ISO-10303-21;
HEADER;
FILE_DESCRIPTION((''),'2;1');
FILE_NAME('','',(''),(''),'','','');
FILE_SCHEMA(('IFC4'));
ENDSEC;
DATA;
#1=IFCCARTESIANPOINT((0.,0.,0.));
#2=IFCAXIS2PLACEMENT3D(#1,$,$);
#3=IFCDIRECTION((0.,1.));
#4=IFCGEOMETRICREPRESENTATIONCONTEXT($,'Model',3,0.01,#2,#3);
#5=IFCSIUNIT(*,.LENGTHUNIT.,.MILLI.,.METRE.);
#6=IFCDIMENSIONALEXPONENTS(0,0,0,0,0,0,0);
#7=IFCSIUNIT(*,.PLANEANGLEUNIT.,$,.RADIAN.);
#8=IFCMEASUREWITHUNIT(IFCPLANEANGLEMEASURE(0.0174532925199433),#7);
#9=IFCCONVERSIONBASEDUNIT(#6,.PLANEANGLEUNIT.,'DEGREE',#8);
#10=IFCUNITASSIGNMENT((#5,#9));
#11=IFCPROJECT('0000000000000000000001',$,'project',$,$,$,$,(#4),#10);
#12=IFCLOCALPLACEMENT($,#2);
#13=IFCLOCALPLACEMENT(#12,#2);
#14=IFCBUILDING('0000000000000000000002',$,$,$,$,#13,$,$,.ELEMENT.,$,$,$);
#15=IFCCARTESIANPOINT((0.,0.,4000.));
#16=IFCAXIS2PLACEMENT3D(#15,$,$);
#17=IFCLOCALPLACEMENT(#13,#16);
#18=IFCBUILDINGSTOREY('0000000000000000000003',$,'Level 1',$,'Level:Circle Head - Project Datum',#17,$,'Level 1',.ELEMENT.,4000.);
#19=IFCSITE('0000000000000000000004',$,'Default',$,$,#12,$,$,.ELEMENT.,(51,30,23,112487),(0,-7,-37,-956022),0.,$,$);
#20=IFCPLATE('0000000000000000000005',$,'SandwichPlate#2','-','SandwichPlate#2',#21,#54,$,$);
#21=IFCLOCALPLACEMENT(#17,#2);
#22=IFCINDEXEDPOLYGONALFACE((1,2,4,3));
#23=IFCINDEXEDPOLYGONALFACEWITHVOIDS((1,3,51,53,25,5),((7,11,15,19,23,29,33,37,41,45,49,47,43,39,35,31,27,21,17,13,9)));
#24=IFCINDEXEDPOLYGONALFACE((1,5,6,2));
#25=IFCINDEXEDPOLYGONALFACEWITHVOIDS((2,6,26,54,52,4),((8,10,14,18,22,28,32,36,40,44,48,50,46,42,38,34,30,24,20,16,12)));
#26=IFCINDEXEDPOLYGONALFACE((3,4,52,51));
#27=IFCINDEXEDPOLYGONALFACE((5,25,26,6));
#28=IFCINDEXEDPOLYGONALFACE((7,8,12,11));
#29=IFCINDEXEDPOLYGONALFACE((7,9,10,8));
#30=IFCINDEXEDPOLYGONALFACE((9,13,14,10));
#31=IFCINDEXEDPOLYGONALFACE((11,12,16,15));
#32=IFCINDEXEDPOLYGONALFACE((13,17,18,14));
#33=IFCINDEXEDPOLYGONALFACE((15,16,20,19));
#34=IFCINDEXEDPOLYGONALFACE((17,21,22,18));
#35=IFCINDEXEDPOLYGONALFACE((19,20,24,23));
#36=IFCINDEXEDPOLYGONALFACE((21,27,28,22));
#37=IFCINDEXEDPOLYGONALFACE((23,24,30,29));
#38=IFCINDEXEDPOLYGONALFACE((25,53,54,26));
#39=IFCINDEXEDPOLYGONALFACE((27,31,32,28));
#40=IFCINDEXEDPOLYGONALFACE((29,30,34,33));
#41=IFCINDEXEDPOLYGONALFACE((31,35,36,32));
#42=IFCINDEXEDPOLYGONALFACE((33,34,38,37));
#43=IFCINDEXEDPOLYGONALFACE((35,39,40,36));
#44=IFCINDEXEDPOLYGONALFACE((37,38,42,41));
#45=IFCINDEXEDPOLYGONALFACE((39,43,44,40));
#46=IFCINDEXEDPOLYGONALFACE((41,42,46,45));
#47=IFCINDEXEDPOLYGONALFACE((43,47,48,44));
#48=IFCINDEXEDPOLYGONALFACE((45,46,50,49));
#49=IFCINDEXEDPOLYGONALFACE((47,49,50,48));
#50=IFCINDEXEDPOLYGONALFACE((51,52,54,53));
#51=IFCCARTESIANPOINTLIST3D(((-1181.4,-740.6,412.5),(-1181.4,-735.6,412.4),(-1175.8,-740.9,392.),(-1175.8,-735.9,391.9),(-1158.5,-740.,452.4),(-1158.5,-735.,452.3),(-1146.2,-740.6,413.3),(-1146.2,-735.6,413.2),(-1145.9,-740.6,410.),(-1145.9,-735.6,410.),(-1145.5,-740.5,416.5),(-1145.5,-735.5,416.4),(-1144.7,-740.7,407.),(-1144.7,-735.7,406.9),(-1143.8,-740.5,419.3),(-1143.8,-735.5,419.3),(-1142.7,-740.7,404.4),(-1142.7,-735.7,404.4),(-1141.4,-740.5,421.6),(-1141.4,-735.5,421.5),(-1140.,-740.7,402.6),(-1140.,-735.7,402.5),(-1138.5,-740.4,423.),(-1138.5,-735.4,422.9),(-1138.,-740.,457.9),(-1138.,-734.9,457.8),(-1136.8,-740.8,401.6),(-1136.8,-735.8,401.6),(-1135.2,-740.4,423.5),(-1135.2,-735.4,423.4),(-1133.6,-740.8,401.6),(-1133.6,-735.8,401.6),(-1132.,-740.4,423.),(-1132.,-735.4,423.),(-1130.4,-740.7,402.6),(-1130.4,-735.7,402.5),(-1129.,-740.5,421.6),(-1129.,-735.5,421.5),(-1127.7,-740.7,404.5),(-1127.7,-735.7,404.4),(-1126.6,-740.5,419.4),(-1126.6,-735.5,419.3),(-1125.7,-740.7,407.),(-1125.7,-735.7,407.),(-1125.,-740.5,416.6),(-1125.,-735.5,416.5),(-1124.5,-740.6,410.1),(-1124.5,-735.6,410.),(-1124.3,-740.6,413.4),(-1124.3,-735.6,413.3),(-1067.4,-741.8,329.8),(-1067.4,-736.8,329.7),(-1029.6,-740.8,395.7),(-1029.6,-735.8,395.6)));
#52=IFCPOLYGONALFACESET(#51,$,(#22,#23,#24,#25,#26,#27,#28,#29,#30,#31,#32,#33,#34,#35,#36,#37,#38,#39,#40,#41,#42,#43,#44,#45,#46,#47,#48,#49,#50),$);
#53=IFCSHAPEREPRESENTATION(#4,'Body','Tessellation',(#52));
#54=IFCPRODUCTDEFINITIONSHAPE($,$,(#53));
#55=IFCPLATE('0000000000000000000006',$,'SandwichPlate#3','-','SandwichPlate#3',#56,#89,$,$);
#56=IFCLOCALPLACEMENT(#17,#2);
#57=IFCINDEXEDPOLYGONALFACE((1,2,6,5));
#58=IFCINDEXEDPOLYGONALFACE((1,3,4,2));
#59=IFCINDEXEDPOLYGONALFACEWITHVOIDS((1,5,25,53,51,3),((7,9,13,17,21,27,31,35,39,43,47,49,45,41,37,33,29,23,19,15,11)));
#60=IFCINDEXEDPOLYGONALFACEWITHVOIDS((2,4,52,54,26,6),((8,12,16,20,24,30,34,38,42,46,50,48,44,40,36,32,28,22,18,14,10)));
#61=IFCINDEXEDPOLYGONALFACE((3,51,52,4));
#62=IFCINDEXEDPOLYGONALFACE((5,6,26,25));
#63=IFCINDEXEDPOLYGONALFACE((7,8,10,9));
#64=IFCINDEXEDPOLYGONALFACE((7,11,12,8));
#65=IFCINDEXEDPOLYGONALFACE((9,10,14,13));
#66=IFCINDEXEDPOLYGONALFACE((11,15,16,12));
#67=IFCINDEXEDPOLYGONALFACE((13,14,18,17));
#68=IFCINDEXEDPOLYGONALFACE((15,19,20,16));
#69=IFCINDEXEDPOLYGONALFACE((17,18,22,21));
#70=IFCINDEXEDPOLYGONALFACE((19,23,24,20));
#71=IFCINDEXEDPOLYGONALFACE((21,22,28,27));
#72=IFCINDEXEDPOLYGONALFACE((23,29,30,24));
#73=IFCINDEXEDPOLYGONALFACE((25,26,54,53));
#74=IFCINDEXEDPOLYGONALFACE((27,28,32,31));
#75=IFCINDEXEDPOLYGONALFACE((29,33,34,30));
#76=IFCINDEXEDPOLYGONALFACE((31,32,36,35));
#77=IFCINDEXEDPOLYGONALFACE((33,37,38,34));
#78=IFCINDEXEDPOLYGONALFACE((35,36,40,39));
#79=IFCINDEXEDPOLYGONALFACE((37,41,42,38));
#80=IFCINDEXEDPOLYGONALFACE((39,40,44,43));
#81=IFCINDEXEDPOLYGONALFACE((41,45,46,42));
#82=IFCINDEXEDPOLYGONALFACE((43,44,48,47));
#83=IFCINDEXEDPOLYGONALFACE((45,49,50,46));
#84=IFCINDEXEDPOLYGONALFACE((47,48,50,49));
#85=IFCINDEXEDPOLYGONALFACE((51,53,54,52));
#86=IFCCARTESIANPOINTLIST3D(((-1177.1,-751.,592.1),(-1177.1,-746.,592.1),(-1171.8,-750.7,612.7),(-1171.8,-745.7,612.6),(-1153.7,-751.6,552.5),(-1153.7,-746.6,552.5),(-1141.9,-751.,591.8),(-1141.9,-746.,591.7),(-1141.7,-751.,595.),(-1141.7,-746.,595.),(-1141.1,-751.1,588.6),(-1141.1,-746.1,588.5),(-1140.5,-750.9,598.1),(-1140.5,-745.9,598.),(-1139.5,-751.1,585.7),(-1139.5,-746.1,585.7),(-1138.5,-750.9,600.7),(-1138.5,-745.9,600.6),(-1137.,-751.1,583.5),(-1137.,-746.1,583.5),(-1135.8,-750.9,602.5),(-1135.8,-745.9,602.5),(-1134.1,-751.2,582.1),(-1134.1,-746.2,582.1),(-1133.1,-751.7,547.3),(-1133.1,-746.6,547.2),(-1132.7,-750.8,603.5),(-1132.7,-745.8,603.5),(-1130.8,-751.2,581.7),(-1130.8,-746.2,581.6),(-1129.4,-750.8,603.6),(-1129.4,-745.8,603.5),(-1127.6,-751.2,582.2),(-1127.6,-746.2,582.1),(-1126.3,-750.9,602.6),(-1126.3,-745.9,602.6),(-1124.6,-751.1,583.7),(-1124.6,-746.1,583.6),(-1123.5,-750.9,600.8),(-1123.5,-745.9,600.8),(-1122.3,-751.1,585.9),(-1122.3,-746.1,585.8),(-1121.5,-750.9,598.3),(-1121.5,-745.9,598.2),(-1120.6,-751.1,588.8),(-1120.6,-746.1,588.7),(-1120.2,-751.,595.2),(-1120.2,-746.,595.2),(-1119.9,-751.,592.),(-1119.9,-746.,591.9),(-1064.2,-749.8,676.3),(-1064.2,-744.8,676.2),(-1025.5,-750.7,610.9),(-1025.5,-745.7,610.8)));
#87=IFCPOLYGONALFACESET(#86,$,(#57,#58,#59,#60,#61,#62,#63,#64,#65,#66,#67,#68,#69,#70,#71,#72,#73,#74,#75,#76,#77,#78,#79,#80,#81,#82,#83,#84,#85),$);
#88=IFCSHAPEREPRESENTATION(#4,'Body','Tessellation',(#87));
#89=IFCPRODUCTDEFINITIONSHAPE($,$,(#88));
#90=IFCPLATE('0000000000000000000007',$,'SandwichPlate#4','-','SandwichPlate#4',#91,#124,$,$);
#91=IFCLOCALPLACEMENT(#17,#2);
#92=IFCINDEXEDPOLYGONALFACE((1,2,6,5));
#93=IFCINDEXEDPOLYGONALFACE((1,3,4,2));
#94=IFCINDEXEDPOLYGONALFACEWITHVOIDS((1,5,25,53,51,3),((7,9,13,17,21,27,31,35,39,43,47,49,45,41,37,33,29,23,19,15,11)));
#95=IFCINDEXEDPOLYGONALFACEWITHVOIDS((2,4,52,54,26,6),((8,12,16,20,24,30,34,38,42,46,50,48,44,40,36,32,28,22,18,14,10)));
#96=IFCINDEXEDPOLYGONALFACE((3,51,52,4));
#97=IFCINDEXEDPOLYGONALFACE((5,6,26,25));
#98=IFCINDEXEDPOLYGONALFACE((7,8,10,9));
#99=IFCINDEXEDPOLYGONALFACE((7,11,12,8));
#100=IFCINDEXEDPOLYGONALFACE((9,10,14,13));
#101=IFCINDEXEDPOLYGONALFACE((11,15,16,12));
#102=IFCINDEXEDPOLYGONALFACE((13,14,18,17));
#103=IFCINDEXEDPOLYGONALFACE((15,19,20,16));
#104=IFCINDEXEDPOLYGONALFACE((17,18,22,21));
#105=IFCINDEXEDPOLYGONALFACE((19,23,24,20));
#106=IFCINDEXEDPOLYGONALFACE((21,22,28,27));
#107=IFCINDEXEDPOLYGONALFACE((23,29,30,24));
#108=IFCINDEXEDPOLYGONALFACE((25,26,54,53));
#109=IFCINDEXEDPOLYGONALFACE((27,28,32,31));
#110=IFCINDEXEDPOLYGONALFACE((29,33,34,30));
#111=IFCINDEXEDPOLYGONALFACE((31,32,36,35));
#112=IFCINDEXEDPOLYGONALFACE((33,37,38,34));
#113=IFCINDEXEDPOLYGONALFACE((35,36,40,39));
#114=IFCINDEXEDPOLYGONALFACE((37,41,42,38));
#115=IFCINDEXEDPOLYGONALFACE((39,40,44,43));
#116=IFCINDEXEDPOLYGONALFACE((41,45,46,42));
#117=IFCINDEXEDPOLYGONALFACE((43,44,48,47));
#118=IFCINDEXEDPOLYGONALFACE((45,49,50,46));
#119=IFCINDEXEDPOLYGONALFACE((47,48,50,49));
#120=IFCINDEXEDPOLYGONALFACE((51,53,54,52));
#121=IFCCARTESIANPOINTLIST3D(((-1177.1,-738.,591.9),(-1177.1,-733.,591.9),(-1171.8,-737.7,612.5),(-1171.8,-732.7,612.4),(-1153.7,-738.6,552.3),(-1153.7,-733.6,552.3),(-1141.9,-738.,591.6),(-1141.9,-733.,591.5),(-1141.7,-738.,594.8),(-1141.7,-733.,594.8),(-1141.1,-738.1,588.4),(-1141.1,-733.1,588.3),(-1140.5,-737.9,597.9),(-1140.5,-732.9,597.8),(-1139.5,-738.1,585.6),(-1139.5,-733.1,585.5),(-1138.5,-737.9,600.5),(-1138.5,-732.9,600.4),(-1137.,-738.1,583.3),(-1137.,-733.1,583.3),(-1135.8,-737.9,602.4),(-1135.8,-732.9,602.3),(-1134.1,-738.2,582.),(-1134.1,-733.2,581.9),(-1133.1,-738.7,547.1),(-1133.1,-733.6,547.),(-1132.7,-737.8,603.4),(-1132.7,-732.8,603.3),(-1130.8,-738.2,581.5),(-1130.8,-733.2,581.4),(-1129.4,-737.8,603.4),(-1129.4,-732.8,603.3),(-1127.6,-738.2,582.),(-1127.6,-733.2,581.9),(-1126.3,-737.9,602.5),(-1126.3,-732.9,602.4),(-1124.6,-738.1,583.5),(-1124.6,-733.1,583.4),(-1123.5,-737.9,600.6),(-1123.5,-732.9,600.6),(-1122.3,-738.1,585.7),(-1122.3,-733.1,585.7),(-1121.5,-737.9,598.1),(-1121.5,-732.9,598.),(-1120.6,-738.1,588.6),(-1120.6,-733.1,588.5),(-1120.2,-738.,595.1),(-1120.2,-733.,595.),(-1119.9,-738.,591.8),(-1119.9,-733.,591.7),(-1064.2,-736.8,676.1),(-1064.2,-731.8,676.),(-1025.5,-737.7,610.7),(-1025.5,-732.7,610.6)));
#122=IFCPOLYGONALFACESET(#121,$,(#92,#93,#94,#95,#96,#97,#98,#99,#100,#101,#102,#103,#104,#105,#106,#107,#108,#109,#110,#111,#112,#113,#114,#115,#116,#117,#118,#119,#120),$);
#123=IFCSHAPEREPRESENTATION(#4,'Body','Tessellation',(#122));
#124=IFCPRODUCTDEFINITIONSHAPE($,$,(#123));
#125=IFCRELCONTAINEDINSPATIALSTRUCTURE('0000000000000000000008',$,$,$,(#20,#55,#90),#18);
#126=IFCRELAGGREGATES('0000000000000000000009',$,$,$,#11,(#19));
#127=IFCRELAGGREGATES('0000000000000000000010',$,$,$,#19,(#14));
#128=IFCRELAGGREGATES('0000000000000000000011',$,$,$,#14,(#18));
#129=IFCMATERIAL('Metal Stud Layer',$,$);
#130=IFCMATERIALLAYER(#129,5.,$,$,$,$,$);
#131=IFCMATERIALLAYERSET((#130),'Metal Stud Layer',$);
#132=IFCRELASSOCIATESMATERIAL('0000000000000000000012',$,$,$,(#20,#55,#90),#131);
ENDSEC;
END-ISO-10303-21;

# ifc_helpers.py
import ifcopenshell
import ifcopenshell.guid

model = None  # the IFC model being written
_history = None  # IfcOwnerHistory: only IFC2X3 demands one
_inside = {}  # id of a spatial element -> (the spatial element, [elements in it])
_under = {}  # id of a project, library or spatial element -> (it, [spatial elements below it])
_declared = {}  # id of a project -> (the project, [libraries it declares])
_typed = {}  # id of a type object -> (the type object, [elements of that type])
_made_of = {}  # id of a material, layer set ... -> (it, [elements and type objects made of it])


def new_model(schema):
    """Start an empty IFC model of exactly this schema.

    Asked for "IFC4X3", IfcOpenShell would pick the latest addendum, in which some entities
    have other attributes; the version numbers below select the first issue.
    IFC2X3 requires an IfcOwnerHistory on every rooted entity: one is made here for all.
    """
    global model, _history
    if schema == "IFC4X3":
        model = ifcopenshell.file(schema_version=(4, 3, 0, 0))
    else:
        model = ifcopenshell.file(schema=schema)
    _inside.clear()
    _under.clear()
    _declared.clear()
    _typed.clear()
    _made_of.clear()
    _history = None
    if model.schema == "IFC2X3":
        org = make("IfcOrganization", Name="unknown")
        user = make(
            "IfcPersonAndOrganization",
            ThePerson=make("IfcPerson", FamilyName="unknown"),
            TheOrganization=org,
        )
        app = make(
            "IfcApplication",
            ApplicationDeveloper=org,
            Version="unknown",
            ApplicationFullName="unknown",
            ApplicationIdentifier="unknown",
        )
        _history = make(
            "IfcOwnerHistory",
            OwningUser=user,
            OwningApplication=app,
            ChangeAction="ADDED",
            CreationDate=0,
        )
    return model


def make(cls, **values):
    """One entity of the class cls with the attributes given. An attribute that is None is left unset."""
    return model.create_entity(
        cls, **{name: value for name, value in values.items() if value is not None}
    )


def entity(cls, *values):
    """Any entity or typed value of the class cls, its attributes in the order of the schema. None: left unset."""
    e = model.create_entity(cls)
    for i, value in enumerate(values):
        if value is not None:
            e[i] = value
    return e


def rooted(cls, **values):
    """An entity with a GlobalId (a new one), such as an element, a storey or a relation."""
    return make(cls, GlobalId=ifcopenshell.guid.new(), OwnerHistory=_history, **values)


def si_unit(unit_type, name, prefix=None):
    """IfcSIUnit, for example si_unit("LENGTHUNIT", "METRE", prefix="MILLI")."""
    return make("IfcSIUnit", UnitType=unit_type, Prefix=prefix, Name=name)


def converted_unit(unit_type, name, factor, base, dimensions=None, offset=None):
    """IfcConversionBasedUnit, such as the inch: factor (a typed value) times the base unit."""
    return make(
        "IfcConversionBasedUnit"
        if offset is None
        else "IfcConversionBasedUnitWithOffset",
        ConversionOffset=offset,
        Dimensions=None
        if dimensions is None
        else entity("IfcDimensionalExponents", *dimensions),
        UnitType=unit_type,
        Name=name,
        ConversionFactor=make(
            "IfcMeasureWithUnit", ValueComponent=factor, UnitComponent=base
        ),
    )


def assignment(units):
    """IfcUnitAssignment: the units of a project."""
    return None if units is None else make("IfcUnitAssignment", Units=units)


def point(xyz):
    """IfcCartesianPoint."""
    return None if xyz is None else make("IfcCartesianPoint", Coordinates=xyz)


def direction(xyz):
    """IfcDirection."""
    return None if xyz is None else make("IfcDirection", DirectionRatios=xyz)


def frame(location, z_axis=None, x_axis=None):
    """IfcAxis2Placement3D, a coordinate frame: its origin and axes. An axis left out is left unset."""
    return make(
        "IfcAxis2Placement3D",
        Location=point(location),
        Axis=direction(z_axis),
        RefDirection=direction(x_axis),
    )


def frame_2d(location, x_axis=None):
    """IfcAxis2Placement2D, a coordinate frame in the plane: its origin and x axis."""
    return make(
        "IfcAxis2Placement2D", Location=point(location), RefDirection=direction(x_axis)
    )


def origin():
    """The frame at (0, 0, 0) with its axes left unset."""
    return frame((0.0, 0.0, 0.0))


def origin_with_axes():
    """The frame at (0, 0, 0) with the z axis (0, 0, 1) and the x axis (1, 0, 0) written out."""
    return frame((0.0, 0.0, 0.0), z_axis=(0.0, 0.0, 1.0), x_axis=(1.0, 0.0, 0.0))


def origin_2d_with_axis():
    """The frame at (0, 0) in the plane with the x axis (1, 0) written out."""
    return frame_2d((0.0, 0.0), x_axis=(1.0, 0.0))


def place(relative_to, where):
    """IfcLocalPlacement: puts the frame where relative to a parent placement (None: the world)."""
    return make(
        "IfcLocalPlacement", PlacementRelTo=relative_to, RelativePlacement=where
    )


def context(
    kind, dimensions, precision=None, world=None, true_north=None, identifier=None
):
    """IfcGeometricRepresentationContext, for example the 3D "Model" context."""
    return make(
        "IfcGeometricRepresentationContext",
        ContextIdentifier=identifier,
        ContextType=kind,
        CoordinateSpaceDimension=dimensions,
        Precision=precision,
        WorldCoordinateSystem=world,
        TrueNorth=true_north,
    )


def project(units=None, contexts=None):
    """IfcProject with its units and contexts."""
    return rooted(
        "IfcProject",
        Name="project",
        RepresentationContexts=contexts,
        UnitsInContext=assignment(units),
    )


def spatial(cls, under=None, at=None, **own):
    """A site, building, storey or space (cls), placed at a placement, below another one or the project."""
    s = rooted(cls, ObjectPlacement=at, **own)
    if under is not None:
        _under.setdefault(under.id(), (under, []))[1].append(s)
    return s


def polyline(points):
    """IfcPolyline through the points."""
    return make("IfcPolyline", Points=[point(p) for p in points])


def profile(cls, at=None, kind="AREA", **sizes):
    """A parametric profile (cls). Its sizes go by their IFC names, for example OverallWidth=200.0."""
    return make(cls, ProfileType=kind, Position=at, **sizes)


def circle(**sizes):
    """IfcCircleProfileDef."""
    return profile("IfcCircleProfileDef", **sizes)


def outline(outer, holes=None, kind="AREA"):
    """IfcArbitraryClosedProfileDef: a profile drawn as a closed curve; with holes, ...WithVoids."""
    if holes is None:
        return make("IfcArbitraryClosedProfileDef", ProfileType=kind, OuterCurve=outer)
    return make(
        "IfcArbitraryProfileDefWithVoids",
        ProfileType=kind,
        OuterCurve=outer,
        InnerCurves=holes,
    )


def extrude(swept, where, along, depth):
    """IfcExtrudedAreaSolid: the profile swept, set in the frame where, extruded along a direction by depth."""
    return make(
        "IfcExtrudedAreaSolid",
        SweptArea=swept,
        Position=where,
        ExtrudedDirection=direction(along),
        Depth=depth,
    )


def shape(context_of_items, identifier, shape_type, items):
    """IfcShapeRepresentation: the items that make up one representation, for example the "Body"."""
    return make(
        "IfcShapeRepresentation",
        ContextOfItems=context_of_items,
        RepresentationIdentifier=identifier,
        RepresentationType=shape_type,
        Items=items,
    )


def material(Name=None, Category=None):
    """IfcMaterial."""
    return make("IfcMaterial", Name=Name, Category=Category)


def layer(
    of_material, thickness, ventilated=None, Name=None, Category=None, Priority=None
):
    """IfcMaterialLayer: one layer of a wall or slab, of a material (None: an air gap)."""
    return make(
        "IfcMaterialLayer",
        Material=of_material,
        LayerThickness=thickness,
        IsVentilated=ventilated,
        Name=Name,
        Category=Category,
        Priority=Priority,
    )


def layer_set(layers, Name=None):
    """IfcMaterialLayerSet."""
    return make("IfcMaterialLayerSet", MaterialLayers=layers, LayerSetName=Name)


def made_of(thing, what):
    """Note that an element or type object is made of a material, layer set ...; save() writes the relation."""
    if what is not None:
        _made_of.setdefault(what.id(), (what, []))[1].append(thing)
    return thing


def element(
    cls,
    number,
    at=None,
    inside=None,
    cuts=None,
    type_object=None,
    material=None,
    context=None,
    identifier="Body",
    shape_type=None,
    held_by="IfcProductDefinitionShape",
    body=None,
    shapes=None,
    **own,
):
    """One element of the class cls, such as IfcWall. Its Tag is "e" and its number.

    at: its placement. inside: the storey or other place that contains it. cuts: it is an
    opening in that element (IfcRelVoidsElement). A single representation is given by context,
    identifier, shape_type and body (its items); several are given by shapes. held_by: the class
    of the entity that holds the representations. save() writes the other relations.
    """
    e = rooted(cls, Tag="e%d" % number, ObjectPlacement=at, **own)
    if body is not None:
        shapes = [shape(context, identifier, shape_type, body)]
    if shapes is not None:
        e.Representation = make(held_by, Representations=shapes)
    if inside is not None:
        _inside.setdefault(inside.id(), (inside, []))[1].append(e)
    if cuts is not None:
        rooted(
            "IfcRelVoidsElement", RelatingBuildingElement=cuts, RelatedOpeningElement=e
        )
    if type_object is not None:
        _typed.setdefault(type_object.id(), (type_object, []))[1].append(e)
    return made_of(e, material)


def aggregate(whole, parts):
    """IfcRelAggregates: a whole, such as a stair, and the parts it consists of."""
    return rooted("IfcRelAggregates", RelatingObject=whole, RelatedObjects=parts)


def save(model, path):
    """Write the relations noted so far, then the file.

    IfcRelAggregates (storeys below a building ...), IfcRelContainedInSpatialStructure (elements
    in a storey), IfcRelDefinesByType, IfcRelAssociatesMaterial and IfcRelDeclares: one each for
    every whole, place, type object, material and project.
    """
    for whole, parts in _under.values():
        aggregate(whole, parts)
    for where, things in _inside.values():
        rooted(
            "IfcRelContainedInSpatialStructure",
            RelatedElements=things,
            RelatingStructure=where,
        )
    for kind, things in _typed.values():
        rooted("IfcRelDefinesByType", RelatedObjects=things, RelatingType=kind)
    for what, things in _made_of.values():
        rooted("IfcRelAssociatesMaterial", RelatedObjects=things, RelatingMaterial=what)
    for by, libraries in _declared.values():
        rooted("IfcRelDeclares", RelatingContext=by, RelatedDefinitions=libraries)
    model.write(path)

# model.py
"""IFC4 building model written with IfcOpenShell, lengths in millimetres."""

from ifc_helpers import new_model, entity, si_unit, converted_unit, direction, frame, origin, origin_with_axes, origin_2d_with_axis, place, context, project, spatial, polyline, circle, outline, extrude, material, layer, layer_set, element, save


model = new_model("IFC4")

# Units and contexts
model_context = context("Model", 3, precision=0.01, world=origin(), true_north=direction((0.0, 1.0)))
ifc_project = project(units=[si_unit("LENGTHUNIT", "METRE", prefix="MILLI"), converted_unit("PLANEANGLEUNIT", "DEGREE", entity("IfcPlaneAngleMeasure", 0.0174532925199433), si_unit("PLANEANGLEUNIT", "RADIAN"), dimensions=[0, 0, 0, 0, 0, 0, 0])], contexts=[model_context])

# Site, building, storey
site_placement = place(None, origin())
site = spatial("IfcSite", under=ifc_project, at=site_placement, Name="Default", CompositionType="ELEMENT", RefLatitude=(51, 30, 23, 112487), RefLongitude=(0, -7, -37, -956022), RefElevation=0.0)
building_placement = place(site_placement, origin())
building = spatial("IfcBuilding", under=site, at=building_placement, CompositionType="ELEMENT")
storey_placement = place(building_placement, frame((0.0, 0.0, 4000.0)))
storey = spatial("IfcBuildingStorey", under=building, at=storey_placement, Name="Level 1", ObjectType="Level:Circle Head - Project Datum", LongName="Level 1", CompositionType="ELEMENT", Elevation=4000.0)

# Plates, openings
ifc_material_1 = material(Name="Metal Stud Layer")
ifc_layer_1 = layer(ifc_material_1, 5.0)
ifc_layer_set_1 = layer_set([ifc_layer_1], Name="Metal Stud Layer")
plate_1_placement = place(storey_placement, frame((-1188.8, -740.8, 399.5), z_axis=(0.0, 0.999896, -0.014432), x_axis=(0.497964, 0.012516, 0.867107)))
plate_1 = element("IfcPlate", 1, at=plate_1_placement, inside=storey, material=ifc_layer_set_1, Name="SandwichPlate#2", Description="-", ObjectType="SandwichPlate#2", context=model_context, shape_type="SweptSolid", body=[
    extrude(outline(polyline([(0.0, 0.0), (76.0, 0.0), (76.0, 140.0), (0.0, 140.0), (0.0, 0.0)])), origin_with_axes(), (0.0, 0.0, 1.0), 5.0),
])
opening_1_placement = place(plate_1_placement, frame((0.0, 0.0, 0.0), z_axis=(0.0, 0.0, 1.0), x_axis=(1.0, 0.0, 0.0)))
element("IfcOpeningElement", 2, at=opening_1_placement, cuts=plate_1, ObjectType="Opening", context=model_context, shape_type="SweptSolid", body=[
    extrude(outline(polyline([(0.0, 0.0), (15.0, 0.0), (0.0, 15.0), (0.0, 0.0)])), origin(), (0.0, 0.0, 1.0), 5.0),
])
opening_2_placement = place(plate_1_placement, frame((0.0, 0.0, 0.0), z_axis=(0.0, 0.0, 1.0), x_axis=(1.0, 0.0, 0.0)))
element("IfcOpeningElement", 3, at=opening_2_placement, cuts=plate_1, ObjectType="Opening", context=model_context, shape_type="SweptSolid", body=[
    extrude(outline(polyline([(76.0, 0.0), (76.0, 15.0), (61.0, 0.0), (76.0, 0.0)])), origin(), (0.0, 0.0, 1.0), 5.0),
])
opening_3_placement = place(plate_1_placement, frame((38.0, 40.0, -0.5), z_axis=(0.0, 0.0, 1.0), x_axis=(0.0, 1.0, 0.0)))
element("IfcOpeningElement", 4, at=opening_3_placement, cuts=plate_1, ObjectType="Opening", context=model_context, shape_type="SweptSolid", body=[
    extrude(circle(Radius=11.0, at=origin_2d_with_axis()), origin(), (0.0, 0.0, 1.0), 6.0),
])
plate_2_placement = place(storey_placement, frame((-1146.0, -751.8, 539.6), z_axis=(0.0, 0.999896, -0.014432), x_axis=(-0.508911, 0.012424, 0.860729)))
plate_2 = element("IfcPlate", 5, at=plate_2_placement, inside=storey, material=ifc_layer_set_1, Name="SandwichPlate#3", Description="-", ObjectType="SandwichPlate#3", context=model_context, shape_type="SweptSolid", body=[
    extrude(outline(polyline([(0.0, 0.0), (76.0, 0.0), (76.0, 140.0), (0.0, 140.0), (0.0, 0.0)])), origin_with_axes(), (0.0, 0.0, 1.0), 5.0),
])
opening_4_placement = place(plate_2_placement, frame((0.0, 0.0, 0.0), z_axis=(0.0, 0.0, 1.0), x_axis=(1.0, 0.0, 0.0)))
element("IfcOpeningElement", 6, at=opening_4_placement, cuts=plate_2, ObjectType="Opening", context=model_context, shape_type="SweptSolid", body=[
    extrude(outline(polyline([(0.0, 0.0), (15.0, 0.0), (0.0, 15.0), (0.0, 0.0)])), origin(), (0.0, 0.0, 1.0), 5.0),
])
opening_5_placement = place(plate_2_placement, frame((0.0, 0.0, 0.0), z_axis=(0.0, 0.0, 1.0), x_axis=(1.0, 0.0, 0.0)))
element("IfcOpeningElement", 7, at=opening_5_placement, cuts=plate_2, ObjectType="Opening", context=model_context, shape_type="SweptSolid", body=[
    extrude(outline(polyline([(76.0, 0.0), (76.0, 15.0), (61.0, 0.0), (76.0, 0.0)])), origin(), (0.0, 0.0, 1.0), 5.0),
])
opening_6_placement = place(plate_2_placement, frame((38.0, 40.0, -0.5), z_axis=(0.0, 0.0, 1.0), x_axis=(0.0, 1.0, 0.0)))
element("IfcOpeningElement", 8, at=opening_6_placement, cuts=plate_2, ObjectType="Opening", context=model_context, shape_type="SweptSolid", body=[
    extrude(circle(Radius=11.0, at=origin_2d_with_axis()), origin(), (0.0, 0.0, 1.0), 6.0),
])
plate_3_placement = place(storey_placement, frame((-1146.0, -738.8, 539.4), z_axis=(0.0, 0.999896, -0.014432), x_axis=(-0.508911, 0.012424, 0.860729)))
plate_3 = element("IfcPlate", 9, at=plate_3_placement, inside=storey, material=ifc_layer_set_1, Name="SandwichPlate#4", Description="-", ObjectType="SandwichPlate#4", context=model_context, shape_type="SweptSolid", body=[
    extrude(outline(polyline([(0.0, 0.0), (76.0, 0.0), (76.0, 140.0), (0.0, 140.0), (0.0, 0.0)])), origin_with_axes(), (0.0, 0.0, 1.0), 5.0),
])
opening_7_placement = place(plate_3_placement, frame((0.0, 0.0, 0.0), z_axis=(0.0, 0.0, 1.0), x_axis=(1.0, 0.0, 0.0)))
element("IfcOpeningElement", 10, at=opening_7_placement, cuts=plate_3, ObjectType="Opening", context=model_context, shape_type="SweptSolid", body=[
    extrude(outline(polyline([(0.0, 0.0), (15.0, 0.0), (0.0, 15.0), (0.0, 0.0)])), origin(), (0.0, 0.0, 1.0), 5.0),
])
opening_8_placement = place(plate_3_placement, frame((0.0, 0.0, 0.0), z_axis=(0.0, 0.0, 1.0), x_axis=(1.0, 0.0, 0.0)))
element("IfcOpeningElement", 11, at=opening_8_placement, cuts=plate_3, ObjectType="Opening", context=model_context, shape_type="SweptSolid", body=[
    extrude(outline(polyline([(76.0, 0.0), (76.0, 15.0), (61.0, 0.0), (76.0, 0.0)])), origin(), (0.0, 0.0, 1.0), 5.0),
])
opening_9_placement = place(plate_3_placement, frame((38.0, 40.0, -0.5), z_axis=(0.0, 0.0, 1.0), x_axis=(0.0, 1.0, 0.0)))
element("IfcOpeningElement", 12, at=opening_9_placement, cuts=plate_3, ObjectType="Opening", context=model_context, shape_type="SweptSolid", body=[
    extrude(circle(Radius=11.0, at=origin_2d_with_axis()), origin(), (0.0, 0.0, 1.0), 6.0),
])

save(model, "model.ifc")
